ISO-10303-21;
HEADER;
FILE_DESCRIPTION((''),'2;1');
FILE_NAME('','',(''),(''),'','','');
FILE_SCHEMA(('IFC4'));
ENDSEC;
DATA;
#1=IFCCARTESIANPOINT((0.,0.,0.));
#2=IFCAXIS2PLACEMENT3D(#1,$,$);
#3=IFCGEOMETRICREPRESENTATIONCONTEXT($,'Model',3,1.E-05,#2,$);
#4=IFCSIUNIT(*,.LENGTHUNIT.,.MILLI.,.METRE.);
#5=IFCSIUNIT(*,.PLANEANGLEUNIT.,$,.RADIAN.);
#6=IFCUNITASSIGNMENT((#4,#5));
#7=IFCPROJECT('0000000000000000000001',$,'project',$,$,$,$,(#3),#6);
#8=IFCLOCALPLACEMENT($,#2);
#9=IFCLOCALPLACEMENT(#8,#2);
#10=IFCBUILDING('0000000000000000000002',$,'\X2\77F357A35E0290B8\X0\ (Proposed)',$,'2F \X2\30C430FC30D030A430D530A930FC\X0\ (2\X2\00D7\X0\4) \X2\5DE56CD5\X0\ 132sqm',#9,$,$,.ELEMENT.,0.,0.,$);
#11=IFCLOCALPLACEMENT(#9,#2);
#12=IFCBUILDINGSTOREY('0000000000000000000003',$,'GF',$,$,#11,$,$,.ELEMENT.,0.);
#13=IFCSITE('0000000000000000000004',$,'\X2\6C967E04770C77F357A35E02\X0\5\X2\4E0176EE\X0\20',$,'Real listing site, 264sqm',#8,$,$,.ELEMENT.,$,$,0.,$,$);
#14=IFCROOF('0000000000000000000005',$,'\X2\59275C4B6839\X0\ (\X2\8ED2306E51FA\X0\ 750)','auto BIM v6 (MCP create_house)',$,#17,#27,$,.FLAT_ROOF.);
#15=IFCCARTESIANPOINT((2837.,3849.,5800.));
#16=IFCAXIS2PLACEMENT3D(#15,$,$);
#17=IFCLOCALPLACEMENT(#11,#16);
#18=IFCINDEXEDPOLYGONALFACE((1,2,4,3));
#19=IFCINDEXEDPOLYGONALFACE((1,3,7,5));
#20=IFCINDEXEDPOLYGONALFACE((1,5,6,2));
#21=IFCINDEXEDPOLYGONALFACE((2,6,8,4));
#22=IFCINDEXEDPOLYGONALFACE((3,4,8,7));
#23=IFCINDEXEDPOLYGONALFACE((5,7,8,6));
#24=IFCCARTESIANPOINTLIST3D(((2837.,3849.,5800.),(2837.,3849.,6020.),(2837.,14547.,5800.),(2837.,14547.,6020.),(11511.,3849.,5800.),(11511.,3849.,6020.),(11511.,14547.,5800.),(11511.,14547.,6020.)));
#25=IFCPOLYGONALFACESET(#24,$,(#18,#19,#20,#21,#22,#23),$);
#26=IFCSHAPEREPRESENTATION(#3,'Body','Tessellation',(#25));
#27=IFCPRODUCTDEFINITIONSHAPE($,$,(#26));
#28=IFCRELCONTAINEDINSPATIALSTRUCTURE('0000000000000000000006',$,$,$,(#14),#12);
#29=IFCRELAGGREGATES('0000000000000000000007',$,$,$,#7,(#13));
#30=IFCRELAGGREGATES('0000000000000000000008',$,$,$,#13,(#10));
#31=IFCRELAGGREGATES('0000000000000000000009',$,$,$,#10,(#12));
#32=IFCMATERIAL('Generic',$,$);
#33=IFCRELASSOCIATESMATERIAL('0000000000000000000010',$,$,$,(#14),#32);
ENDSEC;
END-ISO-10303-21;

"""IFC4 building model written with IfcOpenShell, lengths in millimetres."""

from ifc_helpers import new_model, si_unit, frame, frame_2d, origin, place, context, project, spatial, rectangle, extrude, material, element, save


model = new_model("IFC4")

# Units and contexts
model_context = context("Model", 3, precision=1e-05, world=origin())
ifc_project = project(units=[si_unit("LENGTHUNIT", "METRE", prefix="MILLI"), si_unit("PLANEANGLEUNIT", "RADIAN")], contexts=[model_context])

# Site, building, storey
site_placement = place(None, origin())
site = spatial("IfcSite", under=ifc_project, at=site_placement, Name="沖縄県石垣市5丁目20", ObjectType="Real listing site, 264sqm", CompositionType="ELEMENT", RefElevation=0.0)
building_placement = place(site_placement, origin())
building = spatial("IfcBuilding", under=site, at=building_placement, Name="石垣市邸 (Proposed)", ObjectType="2F ツーバイフォー (2×4) 工法 132sqm", CompositionType="ELEMENT", ElevationOfRefHeight=0.0, ElevationOfTerrain=0.0)
storey_placement = place(building_placement, origin())
storey = spatial("IfcBuildingStorey", under=building, at=storey_placement, Name="GF", CompositionType="ELEMENT", Elevation=0.0)

# Shared definitions
ifc_material = material(Name="Generic")

# Roof
roof_placement = place(storey_placement, frame((2837.0, 3849.0, 5800.0)))
element("IfcRoof", 1, at=roof_placement, inside=storey, material=ifc_material, Name="大屋根 (軒の出 750)", Description="auto BIM v6 (MCP create_house)", PredefinedType="FLAT_ROOF", context=model_context, shape_type="SweptSolid", body=[
    extrude(rectangle(XDim=8674.0, YDim=10698.0, at=frame_2d((4337.0, 5349.0))), frame((2837.0, 3849.0, 5800.0)), (0.0, 0.0, 1.0), 220.0),
])

save(model, "model.ifc")
